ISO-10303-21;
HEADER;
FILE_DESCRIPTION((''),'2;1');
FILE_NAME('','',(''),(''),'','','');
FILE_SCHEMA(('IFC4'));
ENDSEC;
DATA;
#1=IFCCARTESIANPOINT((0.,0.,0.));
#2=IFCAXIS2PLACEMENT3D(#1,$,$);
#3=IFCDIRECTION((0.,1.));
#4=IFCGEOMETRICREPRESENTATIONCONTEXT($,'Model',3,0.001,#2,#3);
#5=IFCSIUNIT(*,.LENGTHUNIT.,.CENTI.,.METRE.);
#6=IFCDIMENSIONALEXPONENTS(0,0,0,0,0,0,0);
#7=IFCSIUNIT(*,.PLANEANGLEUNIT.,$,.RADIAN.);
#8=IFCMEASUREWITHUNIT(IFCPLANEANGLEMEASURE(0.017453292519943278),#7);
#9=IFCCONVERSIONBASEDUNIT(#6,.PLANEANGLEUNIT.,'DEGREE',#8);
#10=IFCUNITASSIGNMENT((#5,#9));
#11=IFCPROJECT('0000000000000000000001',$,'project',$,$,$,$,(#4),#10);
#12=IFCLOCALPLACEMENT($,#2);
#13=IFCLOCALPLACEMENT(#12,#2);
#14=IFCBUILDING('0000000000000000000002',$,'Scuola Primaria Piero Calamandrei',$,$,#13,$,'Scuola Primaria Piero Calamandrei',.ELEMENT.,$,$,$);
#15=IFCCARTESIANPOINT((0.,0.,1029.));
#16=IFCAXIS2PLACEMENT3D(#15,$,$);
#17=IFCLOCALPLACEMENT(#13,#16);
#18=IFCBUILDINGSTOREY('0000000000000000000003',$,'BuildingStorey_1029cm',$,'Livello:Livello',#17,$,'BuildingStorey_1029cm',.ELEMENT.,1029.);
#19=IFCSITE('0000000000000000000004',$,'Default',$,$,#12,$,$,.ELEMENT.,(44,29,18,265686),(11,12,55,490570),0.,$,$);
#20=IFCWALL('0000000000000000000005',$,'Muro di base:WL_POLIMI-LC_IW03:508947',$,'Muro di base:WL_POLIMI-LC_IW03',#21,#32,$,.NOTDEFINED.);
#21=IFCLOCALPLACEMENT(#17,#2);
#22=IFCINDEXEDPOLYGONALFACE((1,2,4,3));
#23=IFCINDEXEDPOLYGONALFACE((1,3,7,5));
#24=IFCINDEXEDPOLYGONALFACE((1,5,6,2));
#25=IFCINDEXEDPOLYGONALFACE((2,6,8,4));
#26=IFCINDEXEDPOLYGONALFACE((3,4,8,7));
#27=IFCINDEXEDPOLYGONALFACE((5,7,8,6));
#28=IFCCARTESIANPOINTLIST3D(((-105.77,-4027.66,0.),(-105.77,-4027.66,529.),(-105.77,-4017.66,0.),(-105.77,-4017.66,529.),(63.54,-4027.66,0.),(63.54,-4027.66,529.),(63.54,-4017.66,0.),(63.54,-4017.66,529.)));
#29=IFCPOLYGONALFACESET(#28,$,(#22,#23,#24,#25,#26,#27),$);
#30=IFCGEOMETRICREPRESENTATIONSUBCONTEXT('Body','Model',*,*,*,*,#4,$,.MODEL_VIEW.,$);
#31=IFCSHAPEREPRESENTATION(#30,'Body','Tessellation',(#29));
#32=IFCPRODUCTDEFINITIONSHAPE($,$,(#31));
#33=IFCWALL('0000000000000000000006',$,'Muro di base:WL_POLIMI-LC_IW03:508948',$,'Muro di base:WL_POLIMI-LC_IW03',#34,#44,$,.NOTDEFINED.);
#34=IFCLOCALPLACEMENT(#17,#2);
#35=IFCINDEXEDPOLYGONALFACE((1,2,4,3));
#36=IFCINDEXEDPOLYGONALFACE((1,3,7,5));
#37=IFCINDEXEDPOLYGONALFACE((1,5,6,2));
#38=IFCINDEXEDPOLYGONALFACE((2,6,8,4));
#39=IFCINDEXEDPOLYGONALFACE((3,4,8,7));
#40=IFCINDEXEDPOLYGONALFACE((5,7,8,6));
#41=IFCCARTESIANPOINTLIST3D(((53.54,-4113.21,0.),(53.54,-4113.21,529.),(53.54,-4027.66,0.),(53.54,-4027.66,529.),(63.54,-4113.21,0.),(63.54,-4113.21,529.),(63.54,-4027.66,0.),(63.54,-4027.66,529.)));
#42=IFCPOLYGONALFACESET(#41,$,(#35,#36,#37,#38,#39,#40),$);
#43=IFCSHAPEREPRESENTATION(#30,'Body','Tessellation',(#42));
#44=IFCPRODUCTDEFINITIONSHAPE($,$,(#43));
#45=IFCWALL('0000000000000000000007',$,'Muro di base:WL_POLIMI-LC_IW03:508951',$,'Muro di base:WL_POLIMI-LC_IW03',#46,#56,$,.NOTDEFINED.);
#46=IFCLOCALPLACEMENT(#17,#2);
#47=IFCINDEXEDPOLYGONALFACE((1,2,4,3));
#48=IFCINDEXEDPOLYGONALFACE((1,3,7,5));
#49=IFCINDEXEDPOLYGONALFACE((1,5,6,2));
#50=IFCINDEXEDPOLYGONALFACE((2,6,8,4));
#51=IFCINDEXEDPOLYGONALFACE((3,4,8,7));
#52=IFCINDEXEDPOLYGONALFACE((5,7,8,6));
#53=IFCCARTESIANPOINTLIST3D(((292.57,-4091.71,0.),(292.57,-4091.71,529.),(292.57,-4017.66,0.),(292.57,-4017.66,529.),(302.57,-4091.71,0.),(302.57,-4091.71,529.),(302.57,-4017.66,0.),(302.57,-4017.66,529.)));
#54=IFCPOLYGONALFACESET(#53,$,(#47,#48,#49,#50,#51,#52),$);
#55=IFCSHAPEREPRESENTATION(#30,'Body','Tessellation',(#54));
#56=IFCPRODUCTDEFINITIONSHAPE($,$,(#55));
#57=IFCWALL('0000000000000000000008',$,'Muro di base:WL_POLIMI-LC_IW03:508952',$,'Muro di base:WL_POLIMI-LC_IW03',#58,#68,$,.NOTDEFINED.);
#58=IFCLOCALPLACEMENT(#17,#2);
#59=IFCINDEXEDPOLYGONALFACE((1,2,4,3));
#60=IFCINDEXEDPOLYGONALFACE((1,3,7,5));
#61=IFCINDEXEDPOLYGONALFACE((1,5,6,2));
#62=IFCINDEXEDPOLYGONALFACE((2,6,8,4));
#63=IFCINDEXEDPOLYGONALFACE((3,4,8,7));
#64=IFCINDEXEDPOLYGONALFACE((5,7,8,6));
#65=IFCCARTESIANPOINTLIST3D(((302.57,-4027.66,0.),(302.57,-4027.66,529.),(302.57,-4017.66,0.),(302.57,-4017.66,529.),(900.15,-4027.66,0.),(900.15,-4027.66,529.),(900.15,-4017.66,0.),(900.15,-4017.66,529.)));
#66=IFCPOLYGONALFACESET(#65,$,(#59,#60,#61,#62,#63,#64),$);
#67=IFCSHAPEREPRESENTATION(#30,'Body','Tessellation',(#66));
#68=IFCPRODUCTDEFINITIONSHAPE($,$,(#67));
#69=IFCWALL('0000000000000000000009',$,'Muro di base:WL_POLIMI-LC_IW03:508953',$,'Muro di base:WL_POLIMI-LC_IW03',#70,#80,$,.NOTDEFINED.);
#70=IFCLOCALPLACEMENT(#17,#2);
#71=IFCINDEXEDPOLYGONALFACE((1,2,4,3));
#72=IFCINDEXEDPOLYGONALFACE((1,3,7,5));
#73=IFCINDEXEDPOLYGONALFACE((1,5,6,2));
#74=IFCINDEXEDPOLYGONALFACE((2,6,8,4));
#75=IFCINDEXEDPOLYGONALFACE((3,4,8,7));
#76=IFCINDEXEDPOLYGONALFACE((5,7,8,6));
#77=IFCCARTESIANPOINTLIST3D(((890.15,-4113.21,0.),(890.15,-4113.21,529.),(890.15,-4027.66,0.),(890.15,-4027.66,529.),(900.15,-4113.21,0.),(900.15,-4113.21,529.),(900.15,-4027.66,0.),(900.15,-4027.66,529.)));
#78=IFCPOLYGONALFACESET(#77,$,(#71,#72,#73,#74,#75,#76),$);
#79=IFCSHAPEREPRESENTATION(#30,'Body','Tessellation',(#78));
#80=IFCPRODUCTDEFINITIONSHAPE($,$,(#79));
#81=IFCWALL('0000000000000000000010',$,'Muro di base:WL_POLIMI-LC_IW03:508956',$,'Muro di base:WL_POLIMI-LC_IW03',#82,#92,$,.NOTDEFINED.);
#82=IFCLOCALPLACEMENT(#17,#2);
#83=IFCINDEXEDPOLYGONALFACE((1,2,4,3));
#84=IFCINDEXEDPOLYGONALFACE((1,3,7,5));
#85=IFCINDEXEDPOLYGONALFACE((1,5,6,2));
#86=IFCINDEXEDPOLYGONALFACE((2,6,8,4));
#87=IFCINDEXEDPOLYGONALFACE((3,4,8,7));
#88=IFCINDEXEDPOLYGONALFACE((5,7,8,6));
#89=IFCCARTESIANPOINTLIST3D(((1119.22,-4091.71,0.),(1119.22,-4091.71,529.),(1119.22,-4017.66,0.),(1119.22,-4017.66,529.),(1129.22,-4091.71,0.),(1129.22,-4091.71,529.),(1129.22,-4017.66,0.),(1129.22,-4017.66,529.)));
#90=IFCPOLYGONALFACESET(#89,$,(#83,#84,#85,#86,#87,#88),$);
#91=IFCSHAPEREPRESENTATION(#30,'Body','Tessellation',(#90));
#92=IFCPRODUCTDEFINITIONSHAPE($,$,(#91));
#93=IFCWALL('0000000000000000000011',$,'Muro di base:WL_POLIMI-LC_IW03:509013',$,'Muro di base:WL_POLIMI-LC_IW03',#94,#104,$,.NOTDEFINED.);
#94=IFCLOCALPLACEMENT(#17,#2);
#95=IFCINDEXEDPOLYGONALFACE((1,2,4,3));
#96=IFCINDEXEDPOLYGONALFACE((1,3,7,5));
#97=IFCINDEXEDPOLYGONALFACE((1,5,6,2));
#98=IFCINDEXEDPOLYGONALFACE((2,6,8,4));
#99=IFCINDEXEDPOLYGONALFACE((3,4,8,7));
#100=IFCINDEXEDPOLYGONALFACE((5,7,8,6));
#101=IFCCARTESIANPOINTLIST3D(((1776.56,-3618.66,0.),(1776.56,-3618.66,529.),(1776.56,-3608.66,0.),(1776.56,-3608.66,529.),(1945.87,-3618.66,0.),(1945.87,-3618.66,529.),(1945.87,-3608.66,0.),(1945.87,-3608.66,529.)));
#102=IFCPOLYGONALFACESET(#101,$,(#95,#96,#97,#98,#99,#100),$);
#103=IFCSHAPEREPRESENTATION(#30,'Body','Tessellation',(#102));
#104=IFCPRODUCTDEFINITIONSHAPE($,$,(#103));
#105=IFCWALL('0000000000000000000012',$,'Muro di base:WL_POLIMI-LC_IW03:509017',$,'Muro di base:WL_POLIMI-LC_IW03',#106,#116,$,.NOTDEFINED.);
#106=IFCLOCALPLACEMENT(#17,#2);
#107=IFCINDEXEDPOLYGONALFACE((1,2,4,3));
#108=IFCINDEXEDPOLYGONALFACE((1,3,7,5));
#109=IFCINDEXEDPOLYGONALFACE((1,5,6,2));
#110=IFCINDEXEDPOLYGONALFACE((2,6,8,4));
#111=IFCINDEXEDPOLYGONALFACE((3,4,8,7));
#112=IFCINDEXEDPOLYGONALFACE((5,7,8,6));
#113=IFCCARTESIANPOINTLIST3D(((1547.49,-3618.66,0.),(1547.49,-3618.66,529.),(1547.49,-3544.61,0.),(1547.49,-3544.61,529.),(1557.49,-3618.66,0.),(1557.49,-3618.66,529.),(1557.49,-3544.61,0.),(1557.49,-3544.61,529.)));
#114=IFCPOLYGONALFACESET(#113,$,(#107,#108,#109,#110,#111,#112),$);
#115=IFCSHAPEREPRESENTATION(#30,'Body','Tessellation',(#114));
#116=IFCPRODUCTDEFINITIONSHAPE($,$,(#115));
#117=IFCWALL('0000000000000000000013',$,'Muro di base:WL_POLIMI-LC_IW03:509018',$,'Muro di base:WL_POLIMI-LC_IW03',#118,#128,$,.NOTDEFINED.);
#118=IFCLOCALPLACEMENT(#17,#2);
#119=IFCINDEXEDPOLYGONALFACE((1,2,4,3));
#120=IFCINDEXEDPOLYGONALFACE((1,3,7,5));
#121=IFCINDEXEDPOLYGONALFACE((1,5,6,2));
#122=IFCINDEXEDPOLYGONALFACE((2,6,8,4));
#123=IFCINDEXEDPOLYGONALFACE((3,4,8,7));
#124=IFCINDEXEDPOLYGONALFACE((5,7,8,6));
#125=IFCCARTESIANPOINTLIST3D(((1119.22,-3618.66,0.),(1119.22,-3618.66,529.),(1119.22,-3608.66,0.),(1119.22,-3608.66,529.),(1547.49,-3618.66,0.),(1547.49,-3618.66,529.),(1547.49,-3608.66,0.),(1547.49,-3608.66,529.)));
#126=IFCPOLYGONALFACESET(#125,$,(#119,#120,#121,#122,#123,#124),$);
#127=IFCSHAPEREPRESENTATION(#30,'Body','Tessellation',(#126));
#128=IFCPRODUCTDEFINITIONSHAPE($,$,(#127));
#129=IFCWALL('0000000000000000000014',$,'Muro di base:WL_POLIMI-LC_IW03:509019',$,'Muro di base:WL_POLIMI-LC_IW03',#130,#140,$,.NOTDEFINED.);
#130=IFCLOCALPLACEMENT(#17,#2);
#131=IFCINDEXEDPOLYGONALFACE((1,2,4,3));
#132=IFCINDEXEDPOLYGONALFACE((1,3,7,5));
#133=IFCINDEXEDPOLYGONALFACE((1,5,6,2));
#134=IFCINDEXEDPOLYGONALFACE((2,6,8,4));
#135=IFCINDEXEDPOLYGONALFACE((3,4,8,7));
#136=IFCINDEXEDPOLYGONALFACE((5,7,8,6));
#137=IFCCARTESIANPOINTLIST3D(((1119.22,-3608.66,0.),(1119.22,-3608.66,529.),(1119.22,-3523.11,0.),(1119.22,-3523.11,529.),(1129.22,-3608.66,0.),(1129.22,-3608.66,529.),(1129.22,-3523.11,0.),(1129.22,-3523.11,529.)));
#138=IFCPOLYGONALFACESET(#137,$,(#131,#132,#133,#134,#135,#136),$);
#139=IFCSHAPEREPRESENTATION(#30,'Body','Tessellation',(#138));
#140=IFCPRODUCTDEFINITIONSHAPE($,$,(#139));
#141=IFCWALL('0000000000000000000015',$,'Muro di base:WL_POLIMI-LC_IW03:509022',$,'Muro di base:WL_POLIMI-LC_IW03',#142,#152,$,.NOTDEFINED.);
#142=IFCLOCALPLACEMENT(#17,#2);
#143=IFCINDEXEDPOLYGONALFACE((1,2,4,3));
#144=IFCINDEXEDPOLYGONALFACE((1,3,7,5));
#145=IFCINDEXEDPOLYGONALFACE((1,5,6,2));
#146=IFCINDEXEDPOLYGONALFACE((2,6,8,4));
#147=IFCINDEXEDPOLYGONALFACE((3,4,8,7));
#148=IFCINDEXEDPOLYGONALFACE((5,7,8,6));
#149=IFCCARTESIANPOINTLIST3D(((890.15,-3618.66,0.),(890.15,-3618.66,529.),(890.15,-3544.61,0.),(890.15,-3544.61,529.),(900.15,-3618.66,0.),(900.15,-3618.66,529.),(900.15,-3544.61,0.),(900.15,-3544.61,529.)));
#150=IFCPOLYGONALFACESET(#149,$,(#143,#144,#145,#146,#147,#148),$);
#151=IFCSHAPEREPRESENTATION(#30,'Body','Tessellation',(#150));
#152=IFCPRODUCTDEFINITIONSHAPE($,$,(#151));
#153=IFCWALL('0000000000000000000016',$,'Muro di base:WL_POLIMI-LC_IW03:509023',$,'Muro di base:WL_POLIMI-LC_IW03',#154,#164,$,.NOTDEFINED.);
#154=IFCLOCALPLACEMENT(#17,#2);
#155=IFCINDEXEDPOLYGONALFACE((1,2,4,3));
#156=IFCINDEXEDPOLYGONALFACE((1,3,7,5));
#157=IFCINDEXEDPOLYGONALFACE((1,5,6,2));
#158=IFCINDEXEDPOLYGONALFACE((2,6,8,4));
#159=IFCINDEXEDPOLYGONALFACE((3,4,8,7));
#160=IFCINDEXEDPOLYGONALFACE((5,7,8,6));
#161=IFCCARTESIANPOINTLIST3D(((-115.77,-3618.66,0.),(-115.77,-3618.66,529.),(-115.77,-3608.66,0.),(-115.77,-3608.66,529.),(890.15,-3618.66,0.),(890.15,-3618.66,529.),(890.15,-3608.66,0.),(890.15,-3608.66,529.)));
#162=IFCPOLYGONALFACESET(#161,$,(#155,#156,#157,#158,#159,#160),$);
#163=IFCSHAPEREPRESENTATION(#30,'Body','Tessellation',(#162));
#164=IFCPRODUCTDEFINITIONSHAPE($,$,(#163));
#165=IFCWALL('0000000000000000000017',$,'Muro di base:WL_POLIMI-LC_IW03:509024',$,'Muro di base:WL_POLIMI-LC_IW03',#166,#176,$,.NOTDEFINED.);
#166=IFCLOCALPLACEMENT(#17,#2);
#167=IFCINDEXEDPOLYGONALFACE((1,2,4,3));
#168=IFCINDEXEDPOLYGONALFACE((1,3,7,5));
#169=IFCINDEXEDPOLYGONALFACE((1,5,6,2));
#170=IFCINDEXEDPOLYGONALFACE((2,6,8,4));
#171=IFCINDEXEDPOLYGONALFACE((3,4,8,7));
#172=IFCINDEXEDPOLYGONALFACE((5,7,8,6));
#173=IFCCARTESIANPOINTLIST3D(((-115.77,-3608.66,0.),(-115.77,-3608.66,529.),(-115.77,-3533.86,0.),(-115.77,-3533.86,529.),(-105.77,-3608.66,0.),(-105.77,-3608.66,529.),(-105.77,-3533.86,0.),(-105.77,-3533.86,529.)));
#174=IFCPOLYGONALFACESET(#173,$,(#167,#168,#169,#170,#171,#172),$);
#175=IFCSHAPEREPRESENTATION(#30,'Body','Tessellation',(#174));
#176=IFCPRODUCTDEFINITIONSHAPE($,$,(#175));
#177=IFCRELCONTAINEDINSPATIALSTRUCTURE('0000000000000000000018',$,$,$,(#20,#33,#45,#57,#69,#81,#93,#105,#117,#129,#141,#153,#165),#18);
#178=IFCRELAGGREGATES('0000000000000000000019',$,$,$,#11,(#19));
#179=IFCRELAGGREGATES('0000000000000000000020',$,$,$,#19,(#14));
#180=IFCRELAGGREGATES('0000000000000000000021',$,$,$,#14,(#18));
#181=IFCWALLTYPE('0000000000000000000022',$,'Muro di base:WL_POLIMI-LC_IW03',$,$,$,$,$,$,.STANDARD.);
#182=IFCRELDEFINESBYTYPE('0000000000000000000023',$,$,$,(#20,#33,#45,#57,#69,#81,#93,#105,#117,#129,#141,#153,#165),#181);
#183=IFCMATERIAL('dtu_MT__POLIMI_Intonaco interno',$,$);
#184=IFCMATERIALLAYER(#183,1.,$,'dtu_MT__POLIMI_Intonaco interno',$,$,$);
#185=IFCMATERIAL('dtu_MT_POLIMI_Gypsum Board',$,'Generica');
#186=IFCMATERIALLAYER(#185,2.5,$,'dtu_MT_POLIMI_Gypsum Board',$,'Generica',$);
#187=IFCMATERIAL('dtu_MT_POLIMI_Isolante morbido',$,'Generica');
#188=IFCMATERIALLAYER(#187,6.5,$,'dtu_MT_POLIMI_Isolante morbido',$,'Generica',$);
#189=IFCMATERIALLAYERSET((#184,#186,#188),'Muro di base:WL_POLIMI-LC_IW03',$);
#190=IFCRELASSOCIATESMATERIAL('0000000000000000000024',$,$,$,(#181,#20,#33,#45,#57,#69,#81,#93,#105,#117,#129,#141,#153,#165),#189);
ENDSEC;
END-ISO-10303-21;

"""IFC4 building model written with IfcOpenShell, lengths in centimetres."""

from ifc_helpers import new_model, entity, si_unit, converted_unit, direction, frame, frame_2d, origin, place, context, subcontext, project, spatial, rectangle, extrude, material, layer, layer_set, layer_usage, type_object, element, save


model = new_model("IFC4")

# Units and contexts
model_context = context("Model", 3, precision=0.001, world=origin(), true_north=direction((0.0, 1.0)))
body_context = subcontext(model_context, "Body", "Model", "MODEL_VIEW")
ifc_project = project(units=[si_unit("LENGTHUNIT", "METRE", prefix="CENTI"), converted_unit("PLANEANGLEUNIT", "DEGREE", entity("IfcPlaneAngleMeasure", 0.017453292519943278), si_unit("PLANEANGLEUNIT", "RADIAN"), dimensions=[0, 0, 0, 0, 0, 0, 0])], contexts=[model_context])

# Site, building, storey
site_placement = place(None, origin())
site = spatial("IfcSite", under=ifc_project, at=site_placement, Name="Default", CompositionType="ELEMENT", RefLatitude=(44, 29, 18, 265686), RefLongitude=(11, 12, 55, 490570), RefElevation=0.0)
building_placement = place(site_placement, origin())
building = spatial("IfcBuilding", under=site, at=building_placement, Name="Scuola Primaria Piero Calamandrei", LongName="Scuola Primaria Piero Calamandrei", CompositionType="ELEMENT")
storey_placement = place(building_placement, frame((0.0, 0.0, 1029.0)))
storey = spatial("IfcBuildingStorey", under=building, at=storey_placement, Name="BuildingStorey_1029cm", ObjectType="Livello:Livello", LongName="BuildingStorey_1029cm", CompositionType="ELEMENT", Elevation=1029.0)

# Shared definitions
ifc_material_1 = material(Name="dtu_MT__POLIMI_Intonaco interno")

# Shared definitions
ifc_material_2 = material(Name="dtu_MT_POLIMI_Gypsum Board", Category="Generica")
ifc_material_3 = material(Name="dtu_MT_POLIMI_Isolante morbido", Category="Generica")

# Walls
ifc_layer_1 = layer(ifc_material_1, 1.0, Name="dtu_MT__POLIMI_Intonaco interno")
ifc_layer_2 = layer(ifc_material_2, 2.5, Name="dtu_MT_POLIMI_Gypsum Board", Category="Generica")
ifc_layer_3 = layer(ifc_material_3, 6.5, Name="dtu_MT_POLIMI_Isolante morbido", Category="Generica")
ifc_layer_set_1 = layer_set([ifc_layer_1, ifc_layer_2, ifc_layer_3], Name="Muro di base:WL_POLIMI-LC_IW03")
wall_type_1 = type_object("IfcWallType", Name="Muro di base:WL_POLIMI-LC_IW03", PredefinedType="STANDARD", material=ifc_layer_set_1)
ifc_layer_usage_1 = layer_usage(ifc_layer_set_1, "AXIS2", "NEGATIVE", 5.0)
wall_1_placement = place(storey_placement, frame((63.54, -4022.66, 0.0), z_axis=(0.0, 0.0, 1.0), x_axis=(-1.0, 0.0, 0.0)))
element("IfcWall", 1, at=wall_1_placement, inside=storey, type_object=wall_type_1, material=ifc_layer_usage_1, Name="Muro di base:WL_POLIMI-LC_IW03:508947", ObjectType="Muro di base:WL_POLIMI-LC_IW03", PredefinedType="NOTDEFINED", context=body_context, shape_type="SweptSolid", body=[
    extrude(rectangle(XDim=169.31, YDim=10.0, at=frame_2d((84.66, 0.0), x_axis=(-1.0, 0.0))), origin(), (0.0, 0.0, 1.0), 529.0),
])
ifc_layer_usage_2 = layer_usage(ifc_layer_set_1, "AXIS2", "NEGATIVE", 5.0)
wall_2_placement = place(storey_placement, frame((58.54, -4113.21, 0.0), z_axis=(0.0, 0.0, 1.0), x_axis=(0.0, 1.0, 0.0)))
element("IfcWall", 2, at=wall_2_placement, inside=storey, type_object=wall_type_1, material=ifc_layer_usage_2, Name="Muro di base:WL_POLIMI-LC_IW03:508948", ObjectType="Muro di base:WL_POLIMI-LC_IW03", PredefinedType="NOTDEFINED", context=body_context, shape_type="SweptSolid", body=[
    extrude(rectangle(XDim=85.55, YDim=10.0, at=frame_2d((42.78, 0.0), x_axis=(-1.0, 0.0))), origin(), (0.0, 0.0, 1.0), 529.0),
])
ifc_layer_usage_3 = layer_usage(ifc_layer_set_1, "AXIS2", "NEGATIVE", 5.0)
wall_3_placement = place(storey_placement, frame((297.57, -4017.66, 0.0), z_axis=(0.0, 0.0, 1.0), x_axis=(0.0, -1.0, 0.0)))
element("IfcWall", 3, at=wall_3_placement, inside=storey, type_object=wall_type_1, material=ifc_layer_usage_3, Name="Muro di base:WL_POLIMI-LC_IW03:508951", ObjectType="Muro di base:WL_POLIMI-LC_IW03", PredefinedType="NOTDEFINED", context=body_context, shape_type="SweptSolid", body=[
    extrude(rectangle(XDim=74.05, YDim=10.0, at=frame_2d((37.03, 0.0), x_axis=(-1.0, 0.0))), origin(), (0.0, 0.0, 1.0), 529.0),
])
ifc_layer_usage_4 = layer_usage(ifc_layer_set_1, "AXIS2", "NEGATIVE", 5.0)
wall_4_placement = place(storey_placement, frame((900.15, -4022.66, 0.0), z_axis=(0.0, 0.0, 1.0), x_axis=(-1.0, 0.0, 0.0)))
element("IfcWall", 4, at=wall_4_placement, inside=storey, type_object=wall_type_1, material=ifc_layer_usage_4, Name="Muro di base:WL_POLIMI-LC_IW03:508952", ObjectType="Muro di base:WL_POLIMI-LC_IW03", PredefinedType="NOTDEFINED", context=body_context, shape_type="SweptSolid", body=[
    extrude(rectangle(XDim=597.58, YDim=10.0, at=frame_2d((298.79, 0.0), x_axis=(-1.0, 0.0))), origin(), (0.0, 0.0, 1.0), 529.0),
])
ifc_layer_usage_5 = layer_usage(ifc_layer_set_1, "AXIS2", "NEGATIVE", 5.0)
wall_5_placement = place(storey_placement, frame((895.15, -4113.21, 0.0), z_axis=(0.0, 0.0, 1.0), x_axis=(0.0, 1.0, 0.0)))
element("IfcWall", 5, at=wall_5_placement, inside=storey, type_object=wall_type_1, material=ifc_layer_usage_5, Name="Muro di base:WL_POLIMI-LC_IW03:508953", ObjectType="Muro di base:WL_POLIMI-LC_IW03", PredefinedType="NOTDEFINED", context=body_context, shape_type="SweptSolid", body=[
    extrude(rectangle(XDim=85.55, YDim=10.0, at=frame_2d((42.78, 0.0), x_axis=(-1.0, 0.0))), origin(), (0.0, 0.0, 1.0), 529.0),
])
ifc_layer_usage_6 = layer_usage(ifc_layer_set_1, "AXIS2", "NEGATIVE", 5.0)
wall_6_placement = place(storey_placement, frame((1124.22, -4017.66, 0.0), z_axis=(0.0, 0.0, 1.0), x_axis=(0.0, -1.0, 0.0)))
element("IfcWall", 6, at=wall_6_placement, inside=storey, type_object=wall_type_1, material=ifc_layer_usage_6, Name="Muro di base:WL_POLIMI-LC_IW03:508956", ObjectType="Muro di base:WL_POLIMI-LC_IW03", PredefinedType="NOTDEFINED", context=body_context, shape_type="SweptSolid", body=[
    extrude(rectangle(XDim=74.05, YDim=10.0, at=frame_2d((37.03, 0.0), x_axis=(-1.0, 0.0))), origin(), (0.0, 0.0, 1.0), 529.0),
])
ifc_layer_usage_7 = layer_usage(ifc_layer_set_1, "AXIS2", "NEGATIVE", 5.0)
wall_7_placement = place(storey_placement, frame((1776.56, -3613.66, 0.0)))
element("IfcWall", 7, at=wall_7_placement, inside=storey, type_object=wall_type_1, material=ifc_layer_usage_7, Name="Muro di base:WL_POLIMI-LC_IW03:509013", ObjectType="Muro di base:WL_POLIMI-LC_IW03", PredefinedType="NOTDEFINED", context=body_context, shape_type="SweptSolid", body=[
    extrude(rectangle(XDim=169.31, YDim=10.0, at=frame_2d((84.66, 0.0), x_axis=(-1.0, 0.0))), origin(), (0.0, 0.0, 1.0), 529.0),
])
ifc_layer_usage_8 = layer_usage(ifc_layer_set_1, "AXIS2", "NEGATIVE", 5.0)
wall_8_placement = place(storey_placement, frame((1552.49, -3618.66, 0.0), z_axis=(0.0, 0.0, 1.0), x_axis=(0.0, 1.0, 0.0)))
element("IfcWall", 8, at=wall_8_placement, inside=storey, type_object=wall_type_1, material=ifc_layer_usage_8, Name="Muro di base:WL_POLIMI-LC_IW03:509017", ObjectType="Muro di base:WL_POLIMI-LC_IW03", PredefinedType="NOTDEFINED", context=body_context, shape_type="SweptSolid", body=[
    extrude(rectangle(XDim=74.05, YDim=10.0, at=frame_2d((37.03, 0.0), x_axis=(-1.0, 0.0))), origin(), (0.0, 0.0, 1.0), 529.0),
])
ifc_layer_usage_9 = layer_usage(ifc_layer_set_1, "AXIS2", "NEGATIVE", 5.0)
wall_9_placement = place(storey_placement, frame((1119.22, -3613.66, 0.0)))
element("IfcWall", 9, at=wall_9_placement, inside=storey, type_object=wall_type_1, material=ifc_layer_usage_9, Name="Muro di base:WL_POLIMI-LC_IW03:509018", ObjectType="Muro di base:WL_POLIMI-LC_IW03", PredefinedType="NOTDEFINED", context=body_context, shape_type="SweptSolid", body=[
    extrude(rectangle(XDim=428.26, YDim=10.0, at=frame_2d((214.13, 0.0), x_axis=(-1.0, 0.0))), origin(), (0.0, 0.0, 1.0), 529.0),
])
ifc_layer_usage_10 = layer_usage(ifc_layer_set_1, "AXIS2", "NEGATIVE", 5.0)
wall_10_placement = place(storey_placement, frame((1124.22, -3523.11, 0.0), z_axis=(0.0, 0.0, 1.0), x_axis=(0.0, -1.0, 0.0)))
element("IfcWall", 10, at=wall_10_placement, inside=storey, type_object=wall_type_1, material=ifc_layer_usage_10, Name="Muro di base:WL_POLIMI-LC_IW03:509019", ObjectType="Muro di base:WL_POLIMI-LC_IW03", PredefinedType="NOTDEFINED", context=body_context, shape_type="SweptSolid", body=[
    extrude(rectangle(XDim=85.55, YDim=10.0, at=frame_2d((42.78, 0.0), x_axis=(-1.0, 0.0))), origin(), (0.0, 0.0, 1.0), 529.0),
])
ifc_layer_usage_11 = layer_usage(ifc_layer_set_1, "AXIS2", "NEGATIVE", 5.0)
wall_11_placement = place(storey_placement, frame((895.15, -3618.66, 0.0), z_axis=(0.0, 0.0, 1.0), x_axis=(0.0, 1.0, 0.0)))
element("IfcWall", 11, at=wall_11_placement, inside=storey, type_object=wall_type_1, material=ifc_layer_usage_11, Name="Muro di base:WL_POLIMI-LC_IW03:509022", ObjectType="Muro di base:WL_POLIMI-LC_IW03", PredefinedType="NOTDEFINED", context=body_context, shape_type="SweptSolid", body=[
    extrude(rectangle(XDim=74.05, YDim=10.0, at=frame_2d((37.03, 0.0), x_axis=(-1.0, 0.0))), origin(), (0.0, 0.0, 1.0), 529.0),
])
ifc_layer_usage_12 = layer_usage(ifc_layer_set_1, "AXIS2", "NEGATIVE", 5.0)
wall_12_placement = place(storey_placement, frame((-115.77, -3613.66, 0.0)))
element("IfcWall", 12, at=wall_12_placement, inside=storey, type_object=wall_type_1, material=ifc_layer_usage_12, Name="Muro di base:WL_POLIMI-LC_IW03:509023", ObjectType="Muro di base:WL_POLIMI-LC_IW03", PredefinedType="NOTDEFINED", context=body_context, shape_type="SweptSolid", body=[
    extrude(rectangle(XDim=1005.92, YDim=10.0, at=frame_2d((502.96, 0.0), x_axis=(-1.0, 0.0))), origin(), (0.0, 0.0, 1.0), 529.0),
])
ifc_layer_usage_13 = layer_usage(ifc_layer_set_1, "AXIS2", "NEGATIVE", 5.0)
wall_13_placement = place(storey_placement, frame((-110.77, -3533.86, 0.0), z_axis=(0.0, 0.0, 1.0), x_axis=(0.0, -1.0, 0.0)))
element("IfcWall", 13, at=wall_13_placement, inside=storey, type_object=wall_type_1, material=ifc_layer_usage_13, Name="Muro di base:WL_POLIMI-LC_IW03:509024", ObjectType="Muro di base:WL_POLIMI-LC_IW03", PredefinedType="NOTDEFINED", context=body_context, shape_type="SweptSolid", body=[
    extrude(rectangle(XDim=74.8, YDim=10.0, at=frame_2d((37.4, 0.0), x_axis=(-1.0, 0.0))), origin(), (0.0, 0.0, 1.0), 529.0),
])

save(model, "model.ifc")
